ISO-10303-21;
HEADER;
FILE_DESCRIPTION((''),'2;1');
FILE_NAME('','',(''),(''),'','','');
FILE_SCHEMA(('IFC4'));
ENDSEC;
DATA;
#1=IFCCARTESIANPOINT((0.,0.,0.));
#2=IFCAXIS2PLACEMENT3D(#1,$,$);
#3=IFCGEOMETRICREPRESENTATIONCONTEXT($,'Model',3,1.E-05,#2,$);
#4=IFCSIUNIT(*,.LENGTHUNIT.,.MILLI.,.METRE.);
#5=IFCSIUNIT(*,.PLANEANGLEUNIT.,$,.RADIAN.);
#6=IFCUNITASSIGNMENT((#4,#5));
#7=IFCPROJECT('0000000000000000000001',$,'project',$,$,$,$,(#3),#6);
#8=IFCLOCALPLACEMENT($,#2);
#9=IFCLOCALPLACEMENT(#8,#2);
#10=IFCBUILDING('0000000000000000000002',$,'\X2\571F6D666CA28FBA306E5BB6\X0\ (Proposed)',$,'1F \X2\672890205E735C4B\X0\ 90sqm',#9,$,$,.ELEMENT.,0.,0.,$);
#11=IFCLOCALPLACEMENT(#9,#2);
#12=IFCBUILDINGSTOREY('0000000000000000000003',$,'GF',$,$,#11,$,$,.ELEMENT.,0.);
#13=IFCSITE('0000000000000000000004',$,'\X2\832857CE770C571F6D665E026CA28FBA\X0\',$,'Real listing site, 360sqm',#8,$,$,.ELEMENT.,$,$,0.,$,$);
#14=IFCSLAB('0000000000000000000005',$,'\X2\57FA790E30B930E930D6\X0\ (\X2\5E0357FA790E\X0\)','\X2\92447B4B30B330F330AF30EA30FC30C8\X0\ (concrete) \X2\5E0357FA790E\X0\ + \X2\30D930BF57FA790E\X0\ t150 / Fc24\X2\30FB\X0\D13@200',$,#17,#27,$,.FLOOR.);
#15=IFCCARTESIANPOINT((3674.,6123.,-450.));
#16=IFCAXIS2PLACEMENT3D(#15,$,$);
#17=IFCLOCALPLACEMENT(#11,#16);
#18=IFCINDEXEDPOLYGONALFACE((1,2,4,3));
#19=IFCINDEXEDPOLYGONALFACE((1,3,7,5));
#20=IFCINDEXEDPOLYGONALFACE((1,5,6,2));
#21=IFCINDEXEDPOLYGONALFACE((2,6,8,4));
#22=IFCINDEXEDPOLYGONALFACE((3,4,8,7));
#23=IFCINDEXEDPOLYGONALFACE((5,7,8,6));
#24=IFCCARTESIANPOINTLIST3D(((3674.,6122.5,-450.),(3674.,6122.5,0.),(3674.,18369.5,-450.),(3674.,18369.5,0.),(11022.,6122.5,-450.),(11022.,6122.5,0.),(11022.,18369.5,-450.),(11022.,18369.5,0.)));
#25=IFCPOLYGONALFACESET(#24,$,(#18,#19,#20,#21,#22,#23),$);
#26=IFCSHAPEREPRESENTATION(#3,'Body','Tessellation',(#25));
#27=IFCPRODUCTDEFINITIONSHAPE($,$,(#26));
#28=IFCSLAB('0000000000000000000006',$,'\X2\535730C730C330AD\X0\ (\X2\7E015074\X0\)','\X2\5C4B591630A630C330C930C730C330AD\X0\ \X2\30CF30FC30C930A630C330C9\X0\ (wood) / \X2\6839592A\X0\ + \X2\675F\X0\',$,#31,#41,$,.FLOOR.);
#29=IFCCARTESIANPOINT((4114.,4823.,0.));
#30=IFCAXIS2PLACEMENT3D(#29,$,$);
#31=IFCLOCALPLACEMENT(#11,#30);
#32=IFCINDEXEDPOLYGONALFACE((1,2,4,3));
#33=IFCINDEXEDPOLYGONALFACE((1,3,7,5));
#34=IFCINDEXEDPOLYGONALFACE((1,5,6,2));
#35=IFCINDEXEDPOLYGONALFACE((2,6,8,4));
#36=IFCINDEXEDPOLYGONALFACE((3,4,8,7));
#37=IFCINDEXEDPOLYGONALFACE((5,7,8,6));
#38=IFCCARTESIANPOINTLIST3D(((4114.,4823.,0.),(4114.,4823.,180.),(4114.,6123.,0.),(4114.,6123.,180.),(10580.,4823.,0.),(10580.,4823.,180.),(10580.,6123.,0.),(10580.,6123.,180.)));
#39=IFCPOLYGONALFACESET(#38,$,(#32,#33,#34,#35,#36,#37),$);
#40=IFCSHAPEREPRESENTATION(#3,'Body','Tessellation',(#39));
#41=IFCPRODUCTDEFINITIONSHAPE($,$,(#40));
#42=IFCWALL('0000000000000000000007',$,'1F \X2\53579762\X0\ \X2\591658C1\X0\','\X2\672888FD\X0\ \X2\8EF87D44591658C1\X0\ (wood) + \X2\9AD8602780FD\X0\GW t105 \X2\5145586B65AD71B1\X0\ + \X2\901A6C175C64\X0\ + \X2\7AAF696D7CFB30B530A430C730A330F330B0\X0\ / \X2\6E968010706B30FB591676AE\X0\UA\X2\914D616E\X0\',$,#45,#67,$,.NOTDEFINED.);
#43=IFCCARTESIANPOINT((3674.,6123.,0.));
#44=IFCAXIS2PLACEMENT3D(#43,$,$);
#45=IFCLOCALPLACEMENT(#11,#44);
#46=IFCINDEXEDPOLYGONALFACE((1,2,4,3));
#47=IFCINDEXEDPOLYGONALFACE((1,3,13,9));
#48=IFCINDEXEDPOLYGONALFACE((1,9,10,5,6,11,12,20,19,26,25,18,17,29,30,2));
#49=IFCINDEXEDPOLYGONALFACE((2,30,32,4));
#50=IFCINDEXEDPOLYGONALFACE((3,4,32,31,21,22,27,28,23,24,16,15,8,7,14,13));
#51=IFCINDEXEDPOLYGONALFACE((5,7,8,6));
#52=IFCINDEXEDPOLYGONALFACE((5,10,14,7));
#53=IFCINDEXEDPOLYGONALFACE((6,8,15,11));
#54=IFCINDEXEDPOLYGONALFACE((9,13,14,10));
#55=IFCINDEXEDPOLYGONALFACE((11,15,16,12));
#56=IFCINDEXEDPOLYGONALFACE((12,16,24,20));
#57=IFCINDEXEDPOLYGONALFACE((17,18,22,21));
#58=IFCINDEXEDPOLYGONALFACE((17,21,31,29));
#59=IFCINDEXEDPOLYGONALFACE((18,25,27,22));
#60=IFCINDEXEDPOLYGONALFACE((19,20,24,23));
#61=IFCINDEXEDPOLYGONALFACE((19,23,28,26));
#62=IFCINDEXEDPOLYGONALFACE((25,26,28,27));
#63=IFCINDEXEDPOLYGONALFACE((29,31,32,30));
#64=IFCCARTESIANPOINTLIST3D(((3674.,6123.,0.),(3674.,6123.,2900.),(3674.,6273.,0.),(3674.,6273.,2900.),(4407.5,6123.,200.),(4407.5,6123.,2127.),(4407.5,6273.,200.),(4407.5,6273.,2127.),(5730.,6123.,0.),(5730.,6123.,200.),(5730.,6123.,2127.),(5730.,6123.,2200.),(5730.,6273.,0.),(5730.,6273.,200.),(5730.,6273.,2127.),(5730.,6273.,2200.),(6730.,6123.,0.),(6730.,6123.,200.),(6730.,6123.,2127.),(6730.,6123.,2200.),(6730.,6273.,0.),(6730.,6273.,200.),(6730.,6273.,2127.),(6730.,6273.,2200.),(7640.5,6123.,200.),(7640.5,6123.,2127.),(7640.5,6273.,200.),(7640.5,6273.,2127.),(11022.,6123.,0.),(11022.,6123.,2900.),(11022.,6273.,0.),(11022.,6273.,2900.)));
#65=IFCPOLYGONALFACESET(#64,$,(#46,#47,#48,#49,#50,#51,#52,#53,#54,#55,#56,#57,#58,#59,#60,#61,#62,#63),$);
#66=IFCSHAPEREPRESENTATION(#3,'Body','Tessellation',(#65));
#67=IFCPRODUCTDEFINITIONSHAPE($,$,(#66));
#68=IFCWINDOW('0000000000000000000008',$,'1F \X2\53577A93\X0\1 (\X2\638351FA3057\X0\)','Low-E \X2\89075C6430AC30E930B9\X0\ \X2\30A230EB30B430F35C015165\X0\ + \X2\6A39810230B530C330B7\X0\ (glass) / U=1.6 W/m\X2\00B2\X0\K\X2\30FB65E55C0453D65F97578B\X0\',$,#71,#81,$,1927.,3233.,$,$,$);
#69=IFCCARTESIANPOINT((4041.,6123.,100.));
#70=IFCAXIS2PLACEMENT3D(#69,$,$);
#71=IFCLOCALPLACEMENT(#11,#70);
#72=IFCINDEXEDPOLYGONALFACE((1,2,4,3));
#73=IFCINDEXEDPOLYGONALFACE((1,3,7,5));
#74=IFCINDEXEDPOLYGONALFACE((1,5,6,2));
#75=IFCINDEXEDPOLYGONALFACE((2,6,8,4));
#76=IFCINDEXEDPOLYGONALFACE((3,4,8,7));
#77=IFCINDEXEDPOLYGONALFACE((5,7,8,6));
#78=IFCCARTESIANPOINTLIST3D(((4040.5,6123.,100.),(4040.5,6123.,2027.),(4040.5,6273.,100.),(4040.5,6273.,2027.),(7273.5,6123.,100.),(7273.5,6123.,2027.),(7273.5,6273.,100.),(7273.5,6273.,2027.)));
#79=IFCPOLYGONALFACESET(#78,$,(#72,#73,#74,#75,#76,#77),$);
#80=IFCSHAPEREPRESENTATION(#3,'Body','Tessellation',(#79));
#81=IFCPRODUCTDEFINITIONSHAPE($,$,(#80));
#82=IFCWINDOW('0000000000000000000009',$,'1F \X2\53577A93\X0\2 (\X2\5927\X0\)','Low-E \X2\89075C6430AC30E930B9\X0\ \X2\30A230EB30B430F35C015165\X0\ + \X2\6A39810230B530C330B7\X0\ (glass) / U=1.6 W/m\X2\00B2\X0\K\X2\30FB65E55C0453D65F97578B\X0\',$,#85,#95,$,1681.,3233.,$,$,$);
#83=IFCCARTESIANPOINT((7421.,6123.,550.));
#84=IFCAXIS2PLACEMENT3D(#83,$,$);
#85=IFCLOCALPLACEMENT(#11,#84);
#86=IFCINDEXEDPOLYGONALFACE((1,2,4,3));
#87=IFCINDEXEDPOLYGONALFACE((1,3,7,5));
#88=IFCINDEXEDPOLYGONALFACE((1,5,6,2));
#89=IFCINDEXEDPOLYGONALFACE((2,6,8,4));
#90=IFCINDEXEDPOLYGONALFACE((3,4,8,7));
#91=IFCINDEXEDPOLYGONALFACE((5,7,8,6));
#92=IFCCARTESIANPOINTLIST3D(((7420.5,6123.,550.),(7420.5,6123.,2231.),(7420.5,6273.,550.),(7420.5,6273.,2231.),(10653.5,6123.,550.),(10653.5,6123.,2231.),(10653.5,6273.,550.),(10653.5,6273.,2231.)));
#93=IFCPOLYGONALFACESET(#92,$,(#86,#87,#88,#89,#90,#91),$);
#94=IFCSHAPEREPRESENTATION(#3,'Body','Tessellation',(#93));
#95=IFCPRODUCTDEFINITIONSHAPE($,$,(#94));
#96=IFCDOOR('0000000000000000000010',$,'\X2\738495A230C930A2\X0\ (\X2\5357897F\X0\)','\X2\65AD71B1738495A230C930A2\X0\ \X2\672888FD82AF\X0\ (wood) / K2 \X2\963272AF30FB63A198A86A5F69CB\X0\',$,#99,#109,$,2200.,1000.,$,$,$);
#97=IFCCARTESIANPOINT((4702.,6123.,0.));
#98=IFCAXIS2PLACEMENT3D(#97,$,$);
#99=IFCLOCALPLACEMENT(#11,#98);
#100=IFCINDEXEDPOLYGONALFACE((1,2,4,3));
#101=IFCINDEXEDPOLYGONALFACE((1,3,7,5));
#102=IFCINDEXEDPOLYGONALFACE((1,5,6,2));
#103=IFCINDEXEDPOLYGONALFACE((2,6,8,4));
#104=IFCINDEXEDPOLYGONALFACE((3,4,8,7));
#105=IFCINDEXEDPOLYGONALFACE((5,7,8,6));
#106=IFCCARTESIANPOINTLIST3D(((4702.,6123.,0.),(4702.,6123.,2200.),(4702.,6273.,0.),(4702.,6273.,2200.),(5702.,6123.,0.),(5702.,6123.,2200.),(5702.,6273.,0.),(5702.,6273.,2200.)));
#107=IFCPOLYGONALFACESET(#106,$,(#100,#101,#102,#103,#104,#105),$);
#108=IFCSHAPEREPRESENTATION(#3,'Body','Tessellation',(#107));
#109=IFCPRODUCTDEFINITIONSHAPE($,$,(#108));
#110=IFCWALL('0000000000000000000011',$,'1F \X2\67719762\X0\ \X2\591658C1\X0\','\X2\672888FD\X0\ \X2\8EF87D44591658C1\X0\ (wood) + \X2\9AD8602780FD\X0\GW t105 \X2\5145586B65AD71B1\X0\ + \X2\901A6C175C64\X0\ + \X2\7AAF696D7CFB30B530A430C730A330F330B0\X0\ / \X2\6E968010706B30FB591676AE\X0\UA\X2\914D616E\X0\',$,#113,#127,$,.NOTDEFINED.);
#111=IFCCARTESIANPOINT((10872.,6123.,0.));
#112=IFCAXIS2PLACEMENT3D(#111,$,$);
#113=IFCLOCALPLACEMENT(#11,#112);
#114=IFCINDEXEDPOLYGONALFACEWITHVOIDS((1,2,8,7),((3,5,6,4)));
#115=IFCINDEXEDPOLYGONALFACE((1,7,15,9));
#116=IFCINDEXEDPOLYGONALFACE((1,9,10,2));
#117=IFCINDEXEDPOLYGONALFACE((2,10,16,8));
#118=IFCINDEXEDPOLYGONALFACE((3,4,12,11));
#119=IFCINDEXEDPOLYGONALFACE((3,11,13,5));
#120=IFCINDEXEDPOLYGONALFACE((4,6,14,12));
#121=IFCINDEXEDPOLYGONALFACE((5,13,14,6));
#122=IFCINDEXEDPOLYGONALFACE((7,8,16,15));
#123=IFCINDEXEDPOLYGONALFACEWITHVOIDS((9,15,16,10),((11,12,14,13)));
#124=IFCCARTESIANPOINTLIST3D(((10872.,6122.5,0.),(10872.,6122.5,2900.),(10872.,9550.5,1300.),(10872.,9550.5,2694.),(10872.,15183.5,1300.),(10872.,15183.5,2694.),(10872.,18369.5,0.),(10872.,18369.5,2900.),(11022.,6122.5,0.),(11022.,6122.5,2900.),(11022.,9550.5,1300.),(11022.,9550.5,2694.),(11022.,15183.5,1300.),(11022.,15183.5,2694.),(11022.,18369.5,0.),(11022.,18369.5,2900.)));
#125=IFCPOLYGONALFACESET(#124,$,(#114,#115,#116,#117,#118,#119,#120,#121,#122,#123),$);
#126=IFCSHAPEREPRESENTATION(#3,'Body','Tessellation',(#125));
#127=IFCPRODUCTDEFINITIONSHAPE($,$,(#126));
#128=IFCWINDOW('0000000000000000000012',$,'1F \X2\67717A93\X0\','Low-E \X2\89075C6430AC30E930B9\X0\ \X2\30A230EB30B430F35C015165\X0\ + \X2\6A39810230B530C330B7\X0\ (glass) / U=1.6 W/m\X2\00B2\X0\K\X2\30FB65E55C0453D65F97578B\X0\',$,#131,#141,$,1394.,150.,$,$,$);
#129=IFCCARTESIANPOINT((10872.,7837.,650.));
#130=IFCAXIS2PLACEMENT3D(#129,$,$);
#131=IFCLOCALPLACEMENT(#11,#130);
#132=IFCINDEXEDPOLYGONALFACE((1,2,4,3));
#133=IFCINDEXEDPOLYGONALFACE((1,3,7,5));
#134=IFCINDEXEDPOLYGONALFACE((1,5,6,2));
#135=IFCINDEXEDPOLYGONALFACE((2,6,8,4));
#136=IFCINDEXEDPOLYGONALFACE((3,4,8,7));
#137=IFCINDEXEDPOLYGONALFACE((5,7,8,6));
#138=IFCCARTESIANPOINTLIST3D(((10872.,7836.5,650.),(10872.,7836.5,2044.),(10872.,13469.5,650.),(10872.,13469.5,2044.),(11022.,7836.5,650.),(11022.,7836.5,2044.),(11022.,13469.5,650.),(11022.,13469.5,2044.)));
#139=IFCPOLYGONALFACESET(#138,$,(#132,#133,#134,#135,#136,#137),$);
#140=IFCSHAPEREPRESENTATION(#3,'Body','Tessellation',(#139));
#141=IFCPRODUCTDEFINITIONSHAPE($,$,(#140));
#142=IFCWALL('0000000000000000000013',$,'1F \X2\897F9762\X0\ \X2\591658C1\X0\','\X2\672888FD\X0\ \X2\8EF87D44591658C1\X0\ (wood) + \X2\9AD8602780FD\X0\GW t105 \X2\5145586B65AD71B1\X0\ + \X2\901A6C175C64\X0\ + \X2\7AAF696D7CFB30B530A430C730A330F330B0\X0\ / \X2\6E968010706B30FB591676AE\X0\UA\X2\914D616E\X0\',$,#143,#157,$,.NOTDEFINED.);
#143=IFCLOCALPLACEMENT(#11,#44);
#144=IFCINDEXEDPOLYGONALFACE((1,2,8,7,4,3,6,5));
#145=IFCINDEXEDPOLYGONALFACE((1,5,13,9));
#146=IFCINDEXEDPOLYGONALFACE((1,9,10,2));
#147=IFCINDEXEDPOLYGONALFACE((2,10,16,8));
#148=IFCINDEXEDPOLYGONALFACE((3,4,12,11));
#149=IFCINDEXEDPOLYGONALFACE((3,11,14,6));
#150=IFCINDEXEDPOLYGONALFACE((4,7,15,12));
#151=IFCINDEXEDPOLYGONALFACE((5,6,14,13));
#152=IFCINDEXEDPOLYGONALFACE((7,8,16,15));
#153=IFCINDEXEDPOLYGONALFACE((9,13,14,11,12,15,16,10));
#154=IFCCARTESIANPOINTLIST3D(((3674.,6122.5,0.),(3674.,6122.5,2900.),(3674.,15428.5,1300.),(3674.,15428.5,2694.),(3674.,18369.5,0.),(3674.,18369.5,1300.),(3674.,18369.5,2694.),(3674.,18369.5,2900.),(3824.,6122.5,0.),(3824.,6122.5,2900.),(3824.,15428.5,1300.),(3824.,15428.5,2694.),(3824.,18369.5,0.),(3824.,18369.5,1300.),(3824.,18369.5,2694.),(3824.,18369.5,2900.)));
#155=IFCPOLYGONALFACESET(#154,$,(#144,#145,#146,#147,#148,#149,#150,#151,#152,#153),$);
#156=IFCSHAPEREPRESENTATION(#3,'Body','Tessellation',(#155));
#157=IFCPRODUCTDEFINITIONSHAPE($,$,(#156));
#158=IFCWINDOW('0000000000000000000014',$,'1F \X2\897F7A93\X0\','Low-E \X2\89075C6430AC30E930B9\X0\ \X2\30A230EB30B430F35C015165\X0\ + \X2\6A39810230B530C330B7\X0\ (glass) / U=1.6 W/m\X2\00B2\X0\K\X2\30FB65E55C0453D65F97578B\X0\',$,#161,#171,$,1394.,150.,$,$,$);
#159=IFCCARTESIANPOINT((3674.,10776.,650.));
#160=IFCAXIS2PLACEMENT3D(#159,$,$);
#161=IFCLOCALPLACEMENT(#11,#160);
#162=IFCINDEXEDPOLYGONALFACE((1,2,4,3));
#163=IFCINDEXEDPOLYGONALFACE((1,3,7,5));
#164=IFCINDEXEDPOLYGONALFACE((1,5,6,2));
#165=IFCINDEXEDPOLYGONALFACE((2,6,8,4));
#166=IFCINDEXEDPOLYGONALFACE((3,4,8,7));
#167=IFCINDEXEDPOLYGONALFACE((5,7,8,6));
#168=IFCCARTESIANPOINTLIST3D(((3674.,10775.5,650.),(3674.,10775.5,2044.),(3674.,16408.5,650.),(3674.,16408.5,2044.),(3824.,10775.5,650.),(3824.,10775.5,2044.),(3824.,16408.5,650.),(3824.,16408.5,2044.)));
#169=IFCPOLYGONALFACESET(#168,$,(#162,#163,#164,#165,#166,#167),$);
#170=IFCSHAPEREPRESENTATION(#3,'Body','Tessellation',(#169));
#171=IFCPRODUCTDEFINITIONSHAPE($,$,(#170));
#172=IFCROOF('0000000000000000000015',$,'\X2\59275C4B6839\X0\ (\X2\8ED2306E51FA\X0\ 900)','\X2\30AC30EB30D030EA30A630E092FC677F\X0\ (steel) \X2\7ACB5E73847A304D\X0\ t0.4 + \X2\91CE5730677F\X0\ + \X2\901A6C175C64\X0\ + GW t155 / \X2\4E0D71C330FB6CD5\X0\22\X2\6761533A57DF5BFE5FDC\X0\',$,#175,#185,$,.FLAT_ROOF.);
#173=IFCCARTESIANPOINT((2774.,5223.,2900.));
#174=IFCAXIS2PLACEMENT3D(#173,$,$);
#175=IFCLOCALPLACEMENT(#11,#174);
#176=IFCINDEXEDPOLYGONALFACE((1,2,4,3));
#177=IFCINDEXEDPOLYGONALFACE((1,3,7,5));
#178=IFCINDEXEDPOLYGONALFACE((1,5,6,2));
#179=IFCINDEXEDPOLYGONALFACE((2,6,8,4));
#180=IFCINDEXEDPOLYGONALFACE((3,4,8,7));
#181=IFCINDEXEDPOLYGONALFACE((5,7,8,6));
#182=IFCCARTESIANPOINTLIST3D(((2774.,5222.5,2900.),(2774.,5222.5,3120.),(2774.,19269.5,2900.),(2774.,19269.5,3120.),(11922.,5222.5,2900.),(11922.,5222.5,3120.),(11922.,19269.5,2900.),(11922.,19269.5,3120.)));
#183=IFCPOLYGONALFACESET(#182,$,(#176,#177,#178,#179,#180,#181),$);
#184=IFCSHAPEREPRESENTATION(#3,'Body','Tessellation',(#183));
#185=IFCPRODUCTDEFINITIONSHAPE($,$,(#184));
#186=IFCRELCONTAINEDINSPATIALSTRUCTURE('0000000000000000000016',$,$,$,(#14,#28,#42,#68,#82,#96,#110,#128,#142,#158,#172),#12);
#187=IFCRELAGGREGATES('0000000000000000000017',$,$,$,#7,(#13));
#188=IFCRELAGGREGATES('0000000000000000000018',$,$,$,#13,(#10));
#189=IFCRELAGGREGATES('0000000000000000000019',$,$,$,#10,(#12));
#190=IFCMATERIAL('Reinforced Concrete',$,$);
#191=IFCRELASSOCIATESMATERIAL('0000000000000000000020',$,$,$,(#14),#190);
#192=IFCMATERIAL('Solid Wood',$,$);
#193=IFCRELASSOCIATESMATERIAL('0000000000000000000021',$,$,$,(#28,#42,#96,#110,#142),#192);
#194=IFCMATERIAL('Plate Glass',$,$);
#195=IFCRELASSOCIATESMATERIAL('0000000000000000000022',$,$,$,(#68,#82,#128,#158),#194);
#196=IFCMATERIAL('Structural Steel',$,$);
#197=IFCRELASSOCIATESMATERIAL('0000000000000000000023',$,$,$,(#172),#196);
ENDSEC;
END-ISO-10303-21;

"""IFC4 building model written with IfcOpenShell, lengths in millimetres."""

from ifc_helpers import new_model, si_unit, frame, frame_2d, origin, place, context, project, spatial, rectangle, extrude, material, element, fill, save


model = new_model("IFC4")

# Units and contexts
model_context = context("Model", 3, precision=1e-05, world=origin())
ifc_project = project(units=[si_unit("LENGTHUNIT", "METRE", prefix="MILLI"), si_unit("PLANEANGLEUNIT", "RADIAN")], contexts=[model_context])

# Site, building, storey
site_placement = place(None, origin())
site = spatial("IfcSite", under=ifc_project, at=site_placement, Name="茨城県土浦市沢辺", ObjectType="Real listing site, 360sqm", CompositionType="ELEMENT", RefElevation=0.0)
building_placement = place(site_placement, origin())
building = spatial("IfcBuilding", under=site, at=building_placement, Name="土浦沢辺の家 (Proposed)", ObjectType="1F 木造平屋 90sqm", CompositionType="ELEMENT", ElevationOfRefHeight=0.0, ElevationOfTerrain=0.0)
storey_placement = place(building_placement, origin())
storey = spatial("IfcBuildingStorey", under=building, at=storey_placement, Name="GF", CompositionType="ELEMENT", Elevation=0.0)

# Slabs
ifc_material_1 = material(Name="Reinforced Concrete")
slab_1_placement = place(storey_placement, frame((3674.0, 6123.0, -450.0)))
element("IfcSlab", 1, at=slab_1_placement, inside=storey, material=ifc_material_1, Name="基礎スラブ (布基礎)", Description="鉄筋コンクリート (concrete) 布基礎 + ベタ基礎 t150 / Fc24・D13@200", PredefinedType="FLOOR", context=model_context, shape_type="SweptSolid", body=[
    extrude(rectangle(XDim=7348.0, YDim=12247.0, at=frame_2d((3674.0, 6123.0))), frame((3674.0, 6123.0, -450.0)), (0.0, 0.0, 1.0), 450.0),
])
ifc_material_2 = material(Name="Solid Wood")
slab_2_placement = place(storey_placement, frame((4114.0, 4823.0, 0.0)))
element("IfcSlab", 2, at=slab_2_placement, inside=storey, material=ifc_material_2, Name="南デッキ (縁側)", Description="屋外ウッドデッキ ハードウッド (wood) / 根太 + 束", PredefinedType="FLOOR", context=model_context, shape_type="SweptSolid", body=[
    extrude(rectangle(XDim=6466.0, YDim=1300.0, at=frame_2d((3233.0, 650.0))), frame((4114.0, 4823.0, 0.0)), (0.0, 0.0, 1.0), 180.0),
])

# Wall, openings, windows, door
wall_1_placement = place(storey_placement, frame((3674.0, 6123.0, 0.0)))
wall_1 = element("IfcWall", 3, at=wall_1_placement, inside=storey, material=ifc_material_2, Name="1F 南面 外壁", Description="木製 軸組外壁 (wood) + 高性能GW t105 充填断熱 + 通気層 + 窯業系サイディング / 準耐火・外皮UA配慮", PredefinedType="NOTDEFINED", context=model_context, shape_type="SweptSolid", body=[
    extrude(rectangle(XDim=7348.0, YDim=150.0, at=frame_2d((3674.0, 75.0))), frame((3674.0, 6123.0, 0.0)), (0.0, 0.0, 1.0), 2900.0),
])
opening_1_placement = place(storey_placement, frame((4041.0, 6123.0, 100.0)))
opening_1 = element("IfcOpeningElement", 4, at=opening_1_placement, cuts=wall_1, PredefinedType="NOTDEFINED", context=model_context, shape_type="SweptSolid", body=[
    extrude(rectangle(XDim=3233.0, YDim=150.0, at=frame_2d((1616.0, 75.0))), frame((4041.0, 6123.0, 100.0)), (0.0, 0.0, 1.0), 1927.0),
])
opening_2_placement = place(storey_placement, frame((7421.0, 6123.0, 550.0)))
opening_2 = element("IfcOpeningElement", 5, at=opening_2_placement, cuts=wall_1, PredefinedType="NOTDEFINED", context=model_context, shape_type="SweptSolid", body=[
    extrude(rectangle(XDim=3233.0, YDim=150.0, at=frame_2d((1616.0, 75.0))), frame((7421.0, 6123.0, 550.0)), (0.0, 0.0, 1.0), 1681.0),
])
opening_3_placement = place(storey_placement, frame((4702.0, 6123.0, 0.0)))
opening_3 = element("IfcOpeningElement", 6, at=opening_3_placement, cuts=wall_1, PredefinedType="NOTDEFINED", context=model_context, shape_type="SweptSolid", body=[
    extrude(rectangle(XDim=1000.0, YDim=150.0, at=frame_2d((500.0, 75.0))), frame((4702.0, 6123.0, 0.0)), (0.0, 0.0, 1.0), 2200.0),
])
ifc_material_3 = material(Name="Plate Glass")
window_1_placement = place(storey_placement, frame((4041.0, 6123.0, 100.0)))
window_1 = element("IfcWindow", 7, at=window_1_placement, inside=storey, material=ifc_material_3, Name="1F 南窓1 (掃出し)", Description="Low-E 複層ガラス アルゴン封入 + 樹脂サッシ (glass) / U=1.6 W/m²K・日射取得型", OverallHeight=1927.0, OverallWidth=3233.0, context=model_context, shape_type="SweptSolid", body=[
    extrude(rectangle(XDim=3233.0, YDim=150.0, at=frame_2d((1616.0, 75.0))), frame((4041.0, 6123.0, 100.0)), (0.0, 0.0, 1.0), 1927.0),
])
fill(opening_1, window_1)
window_2_placement = place(storey_placement, frame((7421.0, 6123.0, 550.0)))
window_2 = element("IfcWindow", 8, at=window_2_placement, inside=storey, material=ifc_material_3, Name="1F 南窓2 (大)", Description="Low-E 複層ガラス アルゴン封入 + 樹脂サッシ (glass) / U=1.6 W/m²K・日射取得型", OverallHeight=1681.0, OverallWidth=3233.0, context=model_context, shape_type="SweptSolid", body=[
    extrude(rectangle(XDim=3233.0, YDim=150.0, at=frame_2d((1616.0, 75.0))), frame((7421.0, 6123.0, 550.0)), (0.0, 0.0, 1.0), 1681.0),
])
fill(opening_2, window_2)
door_placement = place(storey_placement, frame((4702.0, 6123.0, 0.0)))
door = element("IfcDoor", 9, at=door_placement, inside=storey, material=ifc_material_2, Name="玄関ドア (南西)", Description="断熱玄関ドア 木製芯 (wood) / K2 防犯・採風機構", OverallHeight=2200.0, OverallWidth=1000.0, context=model_context, shape_type="SweptSolid", body=[
    extrude(rectangle(XDim=1000.0, YDim=150.0, at=frame_2d((500.0, 75.0))), frame((4702.0, 6123.0, 0.0)), (0.0, 0.0, 1.0), 2200.0),
])
fill(opening_3, door)

# Walls, openings, windows
wall_2_placement = place(storey_placement, frame((10872.0, 6123.0, 0.0)))
wall_2 = element("IfcWall", 10, at=wall_2_placement, inside=storey, material=ifc_material_2, Name="1F 東面 外壁", Description="木製 軸組外壁 (wood) + 高性能GW t105 充填断熱 + 通気層 + 窯業系サイディング / 準耐火・外皮UA配慮", PredefinedType="NOTDEFINED", context=model_context, shape_type="SweptSolid", body=[
    extrude(rectangle(XDim=150.0, YDim=12247.0, at=frame_2d((75.0, 6123.0))), frame((10872.0, 6123.0, 0.0)), (0.0, 0.0, 1.0), 2900.0),
])
opening_4_placement = place(storey_placement, frame((10872.0, 7837.0, 650.0)))
opening_4 = element("IfcOpeningElement", 11, at=opening_4_placement, cuts=wall_2, PredefinedType="NOTDEFINED", context=model_context, shape_type="SweptSolid", body=[
    extrude(rectangle(XDim=150.0, YDim=5633.0, at=frame_2d((75.0, 2816.0))), frame((10872.0, 7837.0, 650.0)), (0.0, 0.0, 1.0), 1394.0),
])
window_3_placement = place(storey_placement, frame((10872.0, 7837.0, 650.0)))
window_3 = element("IfcWindow", 12, at=window_3_placement, inside=storey, material=ifc_material_3, Name="1F 東窓", Description="Low-E 複層ガラス アルゴン封入 + 樹脂サッシ (glass) / U=1.6 W/m²K・日射取得型", OverallHeight=1394.0, OverallWidth=150.0, context=model_context, shape_type="SweptSolid", body=[
    extrude(rectangle(XDim=150.0, YDim=5633.0, at=frame_2d((75.0, 2816.0))), frame((10872.0, 7837.0, 650.0)), (0.0, 0.0, 1.0), 1394.0),
])
fill(opening_4, window_3)
wall_3_placement = place(storey_placement, frame((3674.0, 6123.0, 0.0)))
wall_3 = element("IfcWall", 13, at=wall_3_placement, inside=storey, material=ifc_material_2, Name="1F 西面 外壁", Description="木製 軸組外壁 (wood) + 高性能GW t105 充填断熱 + 通気層 + 窯業系サイディング / 準耐火・外皮UA配慮", PredefinedType="NOTDEFINED", context=model_context, shape_type="SweptSolid", body=[
    extrude(rectangle(XDim=150.0, YDim=12247.0, at=frame_2d((75.0, 6123.0))), frame((3674.0, 6123.0, 0.0)), (0.0, 0.0, 1.0), 2900.0),
])
opening_5_placement = place(storey_placement, frame((3674.0, 10776.0, 650.0)))
opening_5 = element("IfcOpeningElement", 14, at=opening_5_placement, cuts=wall_3, PredefinedType="NOTDEFINED", context=model_context, shape_type="SweptSolid", body=[
    extrude(rectangle(XDim=150.0, YDim=5633.0, at=frame_2d((75.0, 2816.0))), frame((3674.0, 10776.0, 650.0)), (0.0, 0.0, 1.0), 1394.0),
])
window_4_placement = place(storey_placement, frame((3674.0, 10776.0, 650.0)))
window_4 = element("IfcWindow", 15, at=window_4_placement, inside=storey, material=ifc_material_3, Name="1F 西窓", Description="Low-E 複層ガラス アルゴン封入 + 樹脂サッシ (glass) / U=1.6 W/m²K・日射取得型", OverallHeight=1394.0, OverallWidth=150.0, context=model_context, shape_type="SweptSolid", body=[
    extrude(rectangle(XDim=150.0, YDim=5633.0, at=frame_2d((75.0, 2816.0))), frame((3674.0, 10776.0, 650.0)), (0.0, 0.0, 1.0), 1394.0),
])
fill(opening_5, window_4)

# Roof
ifc_material_4 = material(Name="Structural Steel")
roof_placement = place(storey_placement, frame((2774.0, 5223.0, 2900.0)))
element("IfcRoof", 16, at=roof_placement, inside=storey, material=ifc_material_4, Name="大屋根 (軒の出 900)", Description="ガルバリウム鋼板 (steel) 立平葺き t0.4 + 野地板 + 通気層 + GW t155 / 不燃・法22条区域対応", PredefinedType="FLAT_ROOF", context=model_context, shape_type="SweptSolid", body=[
    extrude(rectangle(XDim=9148.0, YDim=14047.0, at=frame_2d((4574.0, 7023.0))), frame((2774.0, 5223.0, 2900.0)), (0.0, 0.0, 1.0), 220.0),
])

save(model, "model.ifc")
